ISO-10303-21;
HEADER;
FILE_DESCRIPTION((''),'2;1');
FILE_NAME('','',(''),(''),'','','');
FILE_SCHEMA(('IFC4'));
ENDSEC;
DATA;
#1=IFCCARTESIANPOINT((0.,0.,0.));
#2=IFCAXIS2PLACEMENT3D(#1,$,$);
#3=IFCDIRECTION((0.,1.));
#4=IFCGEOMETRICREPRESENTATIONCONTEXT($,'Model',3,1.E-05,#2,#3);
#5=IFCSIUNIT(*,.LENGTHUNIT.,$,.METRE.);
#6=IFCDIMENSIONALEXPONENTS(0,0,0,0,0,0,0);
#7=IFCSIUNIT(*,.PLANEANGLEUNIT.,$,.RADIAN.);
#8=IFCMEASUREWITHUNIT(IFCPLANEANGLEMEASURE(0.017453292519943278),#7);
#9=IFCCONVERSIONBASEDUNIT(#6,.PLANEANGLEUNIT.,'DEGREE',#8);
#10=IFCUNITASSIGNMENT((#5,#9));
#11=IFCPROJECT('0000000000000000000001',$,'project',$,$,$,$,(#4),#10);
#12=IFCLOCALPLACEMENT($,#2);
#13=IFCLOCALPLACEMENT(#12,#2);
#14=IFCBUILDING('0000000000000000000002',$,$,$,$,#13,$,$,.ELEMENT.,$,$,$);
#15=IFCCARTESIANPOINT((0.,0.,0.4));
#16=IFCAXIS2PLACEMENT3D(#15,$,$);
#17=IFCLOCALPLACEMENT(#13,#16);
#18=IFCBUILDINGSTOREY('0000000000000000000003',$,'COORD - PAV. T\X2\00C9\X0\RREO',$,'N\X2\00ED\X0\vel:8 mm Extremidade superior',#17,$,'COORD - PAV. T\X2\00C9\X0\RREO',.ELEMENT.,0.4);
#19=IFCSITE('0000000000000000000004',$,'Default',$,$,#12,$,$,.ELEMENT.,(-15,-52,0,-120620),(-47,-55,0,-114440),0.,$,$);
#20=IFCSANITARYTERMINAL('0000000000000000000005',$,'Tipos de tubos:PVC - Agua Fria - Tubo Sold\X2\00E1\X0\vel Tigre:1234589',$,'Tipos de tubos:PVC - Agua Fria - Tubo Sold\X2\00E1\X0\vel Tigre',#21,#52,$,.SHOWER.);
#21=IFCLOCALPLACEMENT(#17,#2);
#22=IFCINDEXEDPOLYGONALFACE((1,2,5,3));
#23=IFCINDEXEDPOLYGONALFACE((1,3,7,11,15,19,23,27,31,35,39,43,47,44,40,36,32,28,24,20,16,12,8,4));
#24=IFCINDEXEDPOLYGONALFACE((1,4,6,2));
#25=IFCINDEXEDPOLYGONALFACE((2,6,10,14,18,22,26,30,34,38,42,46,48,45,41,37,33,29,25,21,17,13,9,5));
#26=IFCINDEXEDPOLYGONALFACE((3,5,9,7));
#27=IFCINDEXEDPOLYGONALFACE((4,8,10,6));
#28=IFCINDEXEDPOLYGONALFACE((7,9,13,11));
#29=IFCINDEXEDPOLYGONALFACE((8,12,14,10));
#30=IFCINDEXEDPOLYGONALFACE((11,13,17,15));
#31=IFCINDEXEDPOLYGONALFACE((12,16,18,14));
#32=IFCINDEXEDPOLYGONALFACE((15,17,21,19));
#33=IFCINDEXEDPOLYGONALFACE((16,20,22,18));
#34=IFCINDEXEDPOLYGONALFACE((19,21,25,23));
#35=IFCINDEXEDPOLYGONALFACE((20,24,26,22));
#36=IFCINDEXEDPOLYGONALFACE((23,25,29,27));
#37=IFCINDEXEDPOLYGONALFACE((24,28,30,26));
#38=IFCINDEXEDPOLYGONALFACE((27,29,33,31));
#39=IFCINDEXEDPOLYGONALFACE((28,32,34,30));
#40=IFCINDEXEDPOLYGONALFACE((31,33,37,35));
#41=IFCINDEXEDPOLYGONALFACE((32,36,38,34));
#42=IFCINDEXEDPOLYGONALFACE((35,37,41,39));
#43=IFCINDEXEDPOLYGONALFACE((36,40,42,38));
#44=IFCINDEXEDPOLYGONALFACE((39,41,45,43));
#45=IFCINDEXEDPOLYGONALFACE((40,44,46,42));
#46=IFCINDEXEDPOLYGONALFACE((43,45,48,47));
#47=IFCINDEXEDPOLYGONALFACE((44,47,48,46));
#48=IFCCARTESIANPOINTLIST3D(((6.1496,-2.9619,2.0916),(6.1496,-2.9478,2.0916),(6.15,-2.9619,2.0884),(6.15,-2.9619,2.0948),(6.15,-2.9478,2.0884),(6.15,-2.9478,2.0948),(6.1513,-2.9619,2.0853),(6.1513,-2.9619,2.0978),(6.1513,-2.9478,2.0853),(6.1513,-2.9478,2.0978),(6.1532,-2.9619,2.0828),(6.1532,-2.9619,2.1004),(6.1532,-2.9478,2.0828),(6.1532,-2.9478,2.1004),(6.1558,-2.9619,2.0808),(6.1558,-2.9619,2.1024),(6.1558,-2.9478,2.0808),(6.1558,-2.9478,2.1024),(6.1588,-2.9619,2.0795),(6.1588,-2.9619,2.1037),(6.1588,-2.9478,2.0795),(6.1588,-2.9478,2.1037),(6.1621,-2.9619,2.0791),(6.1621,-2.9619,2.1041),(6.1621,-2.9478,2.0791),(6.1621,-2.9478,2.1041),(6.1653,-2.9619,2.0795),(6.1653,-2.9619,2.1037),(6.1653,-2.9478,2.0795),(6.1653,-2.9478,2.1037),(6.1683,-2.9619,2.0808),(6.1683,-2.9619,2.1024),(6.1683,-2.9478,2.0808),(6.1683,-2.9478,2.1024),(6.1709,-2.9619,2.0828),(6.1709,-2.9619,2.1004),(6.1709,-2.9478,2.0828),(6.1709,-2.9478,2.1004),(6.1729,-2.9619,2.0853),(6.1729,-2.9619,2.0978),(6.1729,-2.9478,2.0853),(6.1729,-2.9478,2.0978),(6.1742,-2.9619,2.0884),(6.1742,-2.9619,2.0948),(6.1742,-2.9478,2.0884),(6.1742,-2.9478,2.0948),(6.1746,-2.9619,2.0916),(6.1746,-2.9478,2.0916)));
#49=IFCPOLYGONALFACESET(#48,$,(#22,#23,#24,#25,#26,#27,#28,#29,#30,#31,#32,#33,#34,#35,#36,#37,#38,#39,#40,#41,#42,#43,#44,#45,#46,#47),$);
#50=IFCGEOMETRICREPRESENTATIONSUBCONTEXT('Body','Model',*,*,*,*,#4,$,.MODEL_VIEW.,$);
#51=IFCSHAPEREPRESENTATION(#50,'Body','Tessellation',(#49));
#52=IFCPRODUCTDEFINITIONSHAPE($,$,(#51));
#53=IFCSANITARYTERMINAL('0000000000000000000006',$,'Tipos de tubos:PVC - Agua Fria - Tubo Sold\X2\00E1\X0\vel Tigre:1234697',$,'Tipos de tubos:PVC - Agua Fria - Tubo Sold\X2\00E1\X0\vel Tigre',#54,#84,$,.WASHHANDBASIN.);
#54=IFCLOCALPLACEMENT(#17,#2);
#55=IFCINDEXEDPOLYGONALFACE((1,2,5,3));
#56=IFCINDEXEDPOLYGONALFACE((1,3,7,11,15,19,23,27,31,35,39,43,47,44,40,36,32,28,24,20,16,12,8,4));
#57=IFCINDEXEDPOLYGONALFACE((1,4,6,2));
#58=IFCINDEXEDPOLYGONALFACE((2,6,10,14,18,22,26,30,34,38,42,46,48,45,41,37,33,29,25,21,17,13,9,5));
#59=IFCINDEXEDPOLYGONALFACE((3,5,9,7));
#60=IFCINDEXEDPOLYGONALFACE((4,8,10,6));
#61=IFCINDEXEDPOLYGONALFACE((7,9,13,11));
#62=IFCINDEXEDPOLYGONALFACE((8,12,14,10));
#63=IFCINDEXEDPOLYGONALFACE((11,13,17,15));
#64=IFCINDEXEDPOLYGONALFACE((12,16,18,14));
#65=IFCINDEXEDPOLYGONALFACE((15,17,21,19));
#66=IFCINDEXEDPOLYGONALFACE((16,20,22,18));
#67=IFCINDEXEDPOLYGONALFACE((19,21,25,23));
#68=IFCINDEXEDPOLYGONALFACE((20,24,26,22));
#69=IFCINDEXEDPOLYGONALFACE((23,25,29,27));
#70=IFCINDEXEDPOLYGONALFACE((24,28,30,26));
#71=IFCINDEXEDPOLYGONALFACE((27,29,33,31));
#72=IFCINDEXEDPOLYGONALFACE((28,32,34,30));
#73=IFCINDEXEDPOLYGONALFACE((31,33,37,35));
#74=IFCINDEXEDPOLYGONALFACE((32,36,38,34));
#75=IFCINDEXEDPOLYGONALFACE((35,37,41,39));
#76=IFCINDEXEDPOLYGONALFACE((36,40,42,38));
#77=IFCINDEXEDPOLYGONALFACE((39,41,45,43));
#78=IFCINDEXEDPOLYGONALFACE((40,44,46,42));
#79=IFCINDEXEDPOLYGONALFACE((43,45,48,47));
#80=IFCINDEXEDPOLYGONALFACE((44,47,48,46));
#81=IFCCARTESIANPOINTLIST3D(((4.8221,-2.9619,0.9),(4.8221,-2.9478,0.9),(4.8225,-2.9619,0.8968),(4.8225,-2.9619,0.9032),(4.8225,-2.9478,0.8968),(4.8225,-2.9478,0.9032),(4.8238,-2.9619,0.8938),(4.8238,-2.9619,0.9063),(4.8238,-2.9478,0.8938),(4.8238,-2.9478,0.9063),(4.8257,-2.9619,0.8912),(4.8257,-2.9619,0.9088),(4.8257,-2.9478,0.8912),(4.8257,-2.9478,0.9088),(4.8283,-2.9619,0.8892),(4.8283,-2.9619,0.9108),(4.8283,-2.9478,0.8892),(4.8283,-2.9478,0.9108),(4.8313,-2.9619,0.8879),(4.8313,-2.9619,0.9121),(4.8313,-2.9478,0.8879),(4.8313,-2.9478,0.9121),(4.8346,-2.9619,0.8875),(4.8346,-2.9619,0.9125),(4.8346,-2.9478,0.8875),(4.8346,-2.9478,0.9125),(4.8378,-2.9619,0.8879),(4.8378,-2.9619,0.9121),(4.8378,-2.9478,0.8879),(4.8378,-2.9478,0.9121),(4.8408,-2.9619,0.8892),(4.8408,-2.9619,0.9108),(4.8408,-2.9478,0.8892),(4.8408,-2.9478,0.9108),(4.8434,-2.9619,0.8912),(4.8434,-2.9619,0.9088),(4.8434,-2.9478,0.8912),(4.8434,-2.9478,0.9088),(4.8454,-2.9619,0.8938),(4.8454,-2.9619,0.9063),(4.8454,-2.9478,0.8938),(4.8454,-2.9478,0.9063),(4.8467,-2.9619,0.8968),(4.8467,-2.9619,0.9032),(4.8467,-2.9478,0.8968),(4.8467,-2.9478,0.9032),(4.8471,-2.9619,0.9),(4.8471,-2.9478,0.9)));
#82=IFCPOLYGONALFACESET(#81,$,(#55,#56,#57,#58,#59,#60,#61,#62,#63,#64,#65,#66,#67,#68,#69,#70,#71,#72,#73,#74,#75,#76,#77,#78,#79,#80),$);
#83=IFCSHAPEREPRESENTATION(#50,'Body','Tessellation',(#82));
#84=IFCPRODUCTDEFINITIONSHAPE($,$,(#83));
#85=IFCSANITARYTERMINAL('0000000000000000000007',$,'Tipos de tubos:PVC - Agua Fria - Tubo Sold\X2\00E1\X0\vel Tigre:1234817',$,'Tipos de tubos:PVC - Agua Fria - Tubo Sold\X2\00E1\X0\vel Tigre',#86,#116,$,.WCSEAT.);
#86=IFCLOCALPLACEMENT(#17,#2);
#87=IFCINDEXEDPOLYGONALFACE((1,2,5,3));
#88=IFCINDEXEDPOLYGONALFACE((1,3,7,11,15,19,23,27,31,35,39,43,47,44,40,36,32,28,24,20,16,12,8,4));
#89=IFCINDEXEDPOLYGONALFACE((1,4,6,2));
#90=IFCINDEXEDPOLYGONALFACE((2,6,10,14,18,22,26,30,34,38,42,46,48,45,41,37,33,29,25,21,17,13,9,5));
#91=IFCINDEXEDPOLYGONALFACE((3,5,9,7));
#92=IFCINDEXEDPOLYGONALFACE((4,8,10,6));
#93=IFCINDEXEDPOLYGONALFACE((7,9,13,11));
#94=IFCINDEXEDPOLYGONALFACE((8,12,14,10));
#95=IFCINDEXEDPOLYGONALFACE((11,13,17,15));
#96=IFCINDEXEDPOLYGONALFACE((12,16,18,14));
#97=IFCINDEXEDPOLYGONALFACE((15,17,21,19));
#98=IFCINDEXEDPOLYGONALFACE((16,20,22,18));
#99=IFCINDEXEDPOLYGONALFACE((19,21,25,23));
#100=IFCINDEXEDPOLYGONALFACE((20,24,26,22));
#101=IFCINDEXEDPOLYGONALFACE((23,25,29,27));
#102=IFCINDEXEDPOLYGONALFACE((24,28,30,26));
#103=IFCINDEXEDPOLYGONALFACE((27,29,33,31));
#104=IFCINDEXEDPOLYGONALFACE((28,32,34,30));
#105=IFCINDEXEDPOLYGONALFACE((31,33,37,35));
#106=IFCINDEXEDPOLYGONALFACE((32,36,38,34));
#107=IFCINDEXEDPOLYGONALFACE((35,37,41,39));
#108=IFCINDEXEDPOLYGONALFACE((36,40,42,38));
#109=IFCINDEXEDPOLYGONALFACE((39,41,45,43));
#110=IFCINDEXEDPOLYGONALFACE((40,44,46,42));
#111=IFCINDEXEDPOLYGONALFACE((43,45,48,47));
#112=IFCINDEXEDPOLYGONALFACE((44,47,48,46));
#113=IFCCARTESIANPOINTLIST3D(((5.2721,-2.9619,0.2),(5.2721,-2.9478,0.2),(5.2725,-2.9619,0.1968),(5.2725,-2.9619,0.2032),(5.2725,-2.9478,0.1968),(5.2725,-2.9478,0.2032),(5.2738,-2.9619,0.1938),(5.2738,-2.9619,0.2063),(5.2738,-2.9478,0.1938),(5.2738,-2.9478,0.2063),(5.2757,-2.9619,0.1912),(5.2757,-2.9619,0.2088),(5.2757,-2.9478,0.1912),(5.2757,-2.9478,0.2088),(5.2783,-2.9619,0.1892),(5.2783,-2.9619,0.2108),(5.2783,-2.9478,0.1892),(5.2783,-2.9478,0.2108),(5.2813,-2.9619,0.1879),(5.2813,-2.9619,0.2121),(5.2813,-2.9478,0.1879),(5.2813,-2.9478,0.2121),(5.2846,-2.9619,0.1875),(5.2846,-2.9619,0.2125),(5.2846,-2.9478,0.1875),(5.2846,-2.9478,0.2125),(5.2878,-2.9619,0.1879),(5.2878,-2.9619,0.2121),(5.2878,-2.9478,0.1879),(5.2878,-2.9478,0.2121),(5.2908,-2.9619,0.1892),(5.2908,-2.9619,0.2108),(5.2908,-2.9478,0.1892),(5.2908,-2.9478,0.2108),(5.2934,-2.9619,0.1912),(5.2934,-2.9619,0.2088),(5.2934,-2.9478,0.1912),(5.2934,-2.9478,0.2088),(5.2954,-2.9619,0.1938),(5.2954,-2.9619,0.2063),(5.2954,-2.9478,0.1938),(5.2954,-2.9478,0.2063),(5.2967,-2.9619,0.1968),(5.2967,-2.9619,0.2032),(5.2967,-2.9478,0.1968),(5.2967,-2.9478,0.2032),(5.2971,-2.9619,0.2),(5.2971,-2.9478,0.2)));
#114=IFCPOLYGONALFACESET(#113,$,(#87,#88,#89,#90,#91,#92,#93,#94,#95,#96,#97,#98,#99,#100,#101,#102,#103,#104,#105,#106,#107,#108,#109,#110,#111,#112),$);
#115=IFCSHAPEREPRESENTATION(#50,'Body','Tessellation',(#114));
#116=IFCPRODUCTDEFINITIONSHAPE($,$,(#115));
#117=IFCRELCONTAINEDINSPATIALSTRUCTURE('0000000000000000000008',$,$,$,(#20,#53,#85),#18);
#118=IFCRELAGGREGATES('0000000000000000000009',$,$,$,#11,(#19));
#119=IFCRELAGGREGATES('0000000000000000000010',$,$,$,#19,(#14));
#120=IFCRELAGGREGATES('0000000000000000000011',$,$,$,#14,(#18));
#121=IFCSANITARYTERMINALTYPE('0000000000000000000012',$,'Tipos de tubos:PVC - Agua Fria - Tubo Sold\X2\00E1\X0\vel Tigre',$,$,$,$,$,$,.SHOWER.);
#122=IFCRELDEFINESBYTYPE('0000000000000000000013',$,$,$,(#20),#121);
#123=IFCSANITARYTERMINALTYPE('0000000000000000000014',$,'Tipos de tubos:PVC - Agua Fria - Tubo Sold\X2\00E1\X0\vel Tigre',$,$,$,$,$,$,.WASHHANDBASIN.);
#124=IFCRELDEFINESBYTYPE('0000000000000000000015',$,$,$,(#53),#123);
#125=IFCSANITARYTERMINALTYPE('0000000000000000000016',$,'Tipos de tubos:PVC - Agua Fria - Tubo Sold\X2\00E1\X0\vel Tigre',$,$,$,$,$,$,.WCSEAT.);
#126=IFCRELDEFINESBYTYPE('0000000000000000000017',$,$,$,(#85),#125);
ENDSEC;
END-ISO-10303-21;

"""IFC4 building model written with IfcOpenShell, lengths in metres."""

from ifc_helpers import new_model, entity, si_unit, converted_unit, direction, frame, origin, place, context, subcontext, project, spatial, arc, indexed_curve, outline, extrude, type_object, element, save


model = new_model("IFC4")

# Units and contexts
model_context = context("Model", 3, precision=1e-05, world=origin(), true_north=direction((0.0, 1.0)))
body_context = subcontext(model_context, "Body", "Model", "MODEL_VIEW")
ifc_project = project(units=[si_unit("LENGTHUNIT", "METRE"), converted_unit("PLANEANGLEUNIT", "DEGREE", entity("IfcPlaneAngleMeasure", 0.017453292519943278), si_unit("PLANEANGLEUNIT", "RADIAN"), dimensions=[0, 0, 0, 0, 0, 0, 0])], contexts=[model_context])

# Site, building, storey
site_placement = place(None, origin())
site = spatial("IfcSite", under=ifc_project, at=site_placement, Name="Default", CompositionType="ELEMENT", RefLatitude=(-15, -52, 0, -120620), RefLongitude=(-47, -55, 0, -114440), RefElevation=0.0)
building_placement = place(site_placement, origin())
building = spatial("IfcBuilding", under=site, at=building_placement, CompositionType="ELEMENT")
storey_placement = place(building_placement, frame((0.0, 0.0, 0.4)))
storey = spatial("IfcBuildingStorey", under=building, at=storey_placement, Name="COORD - PAV. TÉRREO", ObjectType="Nível:8 mm Extremidade superior", LongName="COORD - PAV. TÉRREO", CompositionType="ELEMENT", Elevation=0.4)

# Sanitary terminals
sanitary_terminal_type_1 = type_object("IfcSanitaryTerminalType", Name="Tipos de tubos:PVC - Agua Fria - Tubo Soldável Tigre", PredefinedType="SHOWER")
sanitary_terminal_1_placement = place(storey_placement, origin())
element("IfcSanitaryTerminal", 1, at=sanitary_terminal_1_placement, inside=storey, type_object=sanitary_terminal_type_1, Name="Tipos de tubos:PVC - Agua Fria - Tubo Soldável Tigre:1234589", ObjectType="Tipos de tubos:PVC - Agua Fria - Tubo Soldável Tigre", PredefinedType="SHOWER", context=body_context, shape_type="SweptSolid", body=[
    extrude(outline(indexed_curve([(0.0125, 0.0), (0.0088, 0.0088), (0.0, 0.0125), (-0.0088, 0.0088), (-0.0125, 0.0), (-0.0088, -0.0088), (0.0, -0.0125), (0.0088, -0.0088)], segments=[arc(1, 2, 3), arc(3, 4, 5), arc(5, 6, 7), arc(7, 8, 1)], self_intersect=False)), frame((6.1621, -2.9619, 2.0916), z_axis=(0.0, 1.0, 0.0), x_axis=(1.0, 0.0, 0.0)), (0.0, 0.0, 1.0), 0.0141),
])
sanitary_terminal_type_2 = type_object("IfcSanitaryTerminalType", Name="Tipos de tubos:PVC - Agua Fria - Tubo Soldável Tigre", PredefinedType="WASHHANDBASIN")
sanitary_terminal_2_placement = place(storey_placement, origin())
element("IfcSanitaryTerminal", 2, at=sanitary_terminal_2_placement, inside=storey, type_object=sanitary_terminal_type_2, Name="Tipos de tubos:PVC - Agua Fria - Tubo Soldável Tigre:1234697", ObjectType="Tipos de tubos:PVC - Agua Fria - Tubo Soldável Tigre", PredefinedType="WASHHANDBASIN", context=body_context, shape_type="SweptSolid", body=[
    extrude(outline(indexed_curve([(0.0125, 0.0), (0.0088, 0.0088), (0.0, 0.0125), (-0.0088, 0.0088), (-0.0125, 0.0), (-0.0088, -0.0088), (0.0, -0.0125), (0.0088, -0.0088)], segments=[arc(1, 2, 3), arc(3, 4, 5), arc(5, 6, 7), arc(7, 8, 1)], self_intersect=False)), frame((4.8346, -2.9619, 0.9), z_axis=(0.0, 1.0, 0.0), x_axis=(-1.0, 0.0, 0.0)), (0.0, 0.0, 1.0), 0.0141),
])
sanitary_terminal_type_3 = type_object("IfcSanitaryTerminalType", Name="Tipos de tubos:PVC - Agua Fria - Tubo Soldável Tigre", PredefinedType="WCSEAT")
sanitary_terminal_3_placement = place(storey_placement, origin())
element("IfcSanitaryTerminal", 3, at=sanitary_terminal_3_placement, inside=storey, type_object=sanitary_terminal_type_3, Name="Tipos de tubos:PVC - Agua Fria - Tubo Soldável Tigre:1234817", ObjectType="Tipos de tubos:PVC - Agua Fria - Tubo Soldável Tigre", PredefinedType="WCSEAT", context=body_context, shape_type="SweptSolid", body=[
    extrude(outline(indexed_curve([(0.0125, 0.0), (0.0088, 0.0088), (0.0, 0.0125), (-0.0088, 0.0088), (-0.0125, 0.0), (-0.0088, -0.0088), (0.0, -0.0125), (0.0088, -0.0088)], segments=[arc(1, 2, 3), arc(3, 4, 5), arc(5, 6, 7), arc(7, 8, 1)], self_intersect=False)), frame((5.2846, -2.9619, 0.2), z_axis=(0.0, 1.0, 0.0), x_axis=(-1.0, 0.0, 0.0)), (0.0, 0.0, 1.0), 0.0141),
])

save(model, "model.ifc")
